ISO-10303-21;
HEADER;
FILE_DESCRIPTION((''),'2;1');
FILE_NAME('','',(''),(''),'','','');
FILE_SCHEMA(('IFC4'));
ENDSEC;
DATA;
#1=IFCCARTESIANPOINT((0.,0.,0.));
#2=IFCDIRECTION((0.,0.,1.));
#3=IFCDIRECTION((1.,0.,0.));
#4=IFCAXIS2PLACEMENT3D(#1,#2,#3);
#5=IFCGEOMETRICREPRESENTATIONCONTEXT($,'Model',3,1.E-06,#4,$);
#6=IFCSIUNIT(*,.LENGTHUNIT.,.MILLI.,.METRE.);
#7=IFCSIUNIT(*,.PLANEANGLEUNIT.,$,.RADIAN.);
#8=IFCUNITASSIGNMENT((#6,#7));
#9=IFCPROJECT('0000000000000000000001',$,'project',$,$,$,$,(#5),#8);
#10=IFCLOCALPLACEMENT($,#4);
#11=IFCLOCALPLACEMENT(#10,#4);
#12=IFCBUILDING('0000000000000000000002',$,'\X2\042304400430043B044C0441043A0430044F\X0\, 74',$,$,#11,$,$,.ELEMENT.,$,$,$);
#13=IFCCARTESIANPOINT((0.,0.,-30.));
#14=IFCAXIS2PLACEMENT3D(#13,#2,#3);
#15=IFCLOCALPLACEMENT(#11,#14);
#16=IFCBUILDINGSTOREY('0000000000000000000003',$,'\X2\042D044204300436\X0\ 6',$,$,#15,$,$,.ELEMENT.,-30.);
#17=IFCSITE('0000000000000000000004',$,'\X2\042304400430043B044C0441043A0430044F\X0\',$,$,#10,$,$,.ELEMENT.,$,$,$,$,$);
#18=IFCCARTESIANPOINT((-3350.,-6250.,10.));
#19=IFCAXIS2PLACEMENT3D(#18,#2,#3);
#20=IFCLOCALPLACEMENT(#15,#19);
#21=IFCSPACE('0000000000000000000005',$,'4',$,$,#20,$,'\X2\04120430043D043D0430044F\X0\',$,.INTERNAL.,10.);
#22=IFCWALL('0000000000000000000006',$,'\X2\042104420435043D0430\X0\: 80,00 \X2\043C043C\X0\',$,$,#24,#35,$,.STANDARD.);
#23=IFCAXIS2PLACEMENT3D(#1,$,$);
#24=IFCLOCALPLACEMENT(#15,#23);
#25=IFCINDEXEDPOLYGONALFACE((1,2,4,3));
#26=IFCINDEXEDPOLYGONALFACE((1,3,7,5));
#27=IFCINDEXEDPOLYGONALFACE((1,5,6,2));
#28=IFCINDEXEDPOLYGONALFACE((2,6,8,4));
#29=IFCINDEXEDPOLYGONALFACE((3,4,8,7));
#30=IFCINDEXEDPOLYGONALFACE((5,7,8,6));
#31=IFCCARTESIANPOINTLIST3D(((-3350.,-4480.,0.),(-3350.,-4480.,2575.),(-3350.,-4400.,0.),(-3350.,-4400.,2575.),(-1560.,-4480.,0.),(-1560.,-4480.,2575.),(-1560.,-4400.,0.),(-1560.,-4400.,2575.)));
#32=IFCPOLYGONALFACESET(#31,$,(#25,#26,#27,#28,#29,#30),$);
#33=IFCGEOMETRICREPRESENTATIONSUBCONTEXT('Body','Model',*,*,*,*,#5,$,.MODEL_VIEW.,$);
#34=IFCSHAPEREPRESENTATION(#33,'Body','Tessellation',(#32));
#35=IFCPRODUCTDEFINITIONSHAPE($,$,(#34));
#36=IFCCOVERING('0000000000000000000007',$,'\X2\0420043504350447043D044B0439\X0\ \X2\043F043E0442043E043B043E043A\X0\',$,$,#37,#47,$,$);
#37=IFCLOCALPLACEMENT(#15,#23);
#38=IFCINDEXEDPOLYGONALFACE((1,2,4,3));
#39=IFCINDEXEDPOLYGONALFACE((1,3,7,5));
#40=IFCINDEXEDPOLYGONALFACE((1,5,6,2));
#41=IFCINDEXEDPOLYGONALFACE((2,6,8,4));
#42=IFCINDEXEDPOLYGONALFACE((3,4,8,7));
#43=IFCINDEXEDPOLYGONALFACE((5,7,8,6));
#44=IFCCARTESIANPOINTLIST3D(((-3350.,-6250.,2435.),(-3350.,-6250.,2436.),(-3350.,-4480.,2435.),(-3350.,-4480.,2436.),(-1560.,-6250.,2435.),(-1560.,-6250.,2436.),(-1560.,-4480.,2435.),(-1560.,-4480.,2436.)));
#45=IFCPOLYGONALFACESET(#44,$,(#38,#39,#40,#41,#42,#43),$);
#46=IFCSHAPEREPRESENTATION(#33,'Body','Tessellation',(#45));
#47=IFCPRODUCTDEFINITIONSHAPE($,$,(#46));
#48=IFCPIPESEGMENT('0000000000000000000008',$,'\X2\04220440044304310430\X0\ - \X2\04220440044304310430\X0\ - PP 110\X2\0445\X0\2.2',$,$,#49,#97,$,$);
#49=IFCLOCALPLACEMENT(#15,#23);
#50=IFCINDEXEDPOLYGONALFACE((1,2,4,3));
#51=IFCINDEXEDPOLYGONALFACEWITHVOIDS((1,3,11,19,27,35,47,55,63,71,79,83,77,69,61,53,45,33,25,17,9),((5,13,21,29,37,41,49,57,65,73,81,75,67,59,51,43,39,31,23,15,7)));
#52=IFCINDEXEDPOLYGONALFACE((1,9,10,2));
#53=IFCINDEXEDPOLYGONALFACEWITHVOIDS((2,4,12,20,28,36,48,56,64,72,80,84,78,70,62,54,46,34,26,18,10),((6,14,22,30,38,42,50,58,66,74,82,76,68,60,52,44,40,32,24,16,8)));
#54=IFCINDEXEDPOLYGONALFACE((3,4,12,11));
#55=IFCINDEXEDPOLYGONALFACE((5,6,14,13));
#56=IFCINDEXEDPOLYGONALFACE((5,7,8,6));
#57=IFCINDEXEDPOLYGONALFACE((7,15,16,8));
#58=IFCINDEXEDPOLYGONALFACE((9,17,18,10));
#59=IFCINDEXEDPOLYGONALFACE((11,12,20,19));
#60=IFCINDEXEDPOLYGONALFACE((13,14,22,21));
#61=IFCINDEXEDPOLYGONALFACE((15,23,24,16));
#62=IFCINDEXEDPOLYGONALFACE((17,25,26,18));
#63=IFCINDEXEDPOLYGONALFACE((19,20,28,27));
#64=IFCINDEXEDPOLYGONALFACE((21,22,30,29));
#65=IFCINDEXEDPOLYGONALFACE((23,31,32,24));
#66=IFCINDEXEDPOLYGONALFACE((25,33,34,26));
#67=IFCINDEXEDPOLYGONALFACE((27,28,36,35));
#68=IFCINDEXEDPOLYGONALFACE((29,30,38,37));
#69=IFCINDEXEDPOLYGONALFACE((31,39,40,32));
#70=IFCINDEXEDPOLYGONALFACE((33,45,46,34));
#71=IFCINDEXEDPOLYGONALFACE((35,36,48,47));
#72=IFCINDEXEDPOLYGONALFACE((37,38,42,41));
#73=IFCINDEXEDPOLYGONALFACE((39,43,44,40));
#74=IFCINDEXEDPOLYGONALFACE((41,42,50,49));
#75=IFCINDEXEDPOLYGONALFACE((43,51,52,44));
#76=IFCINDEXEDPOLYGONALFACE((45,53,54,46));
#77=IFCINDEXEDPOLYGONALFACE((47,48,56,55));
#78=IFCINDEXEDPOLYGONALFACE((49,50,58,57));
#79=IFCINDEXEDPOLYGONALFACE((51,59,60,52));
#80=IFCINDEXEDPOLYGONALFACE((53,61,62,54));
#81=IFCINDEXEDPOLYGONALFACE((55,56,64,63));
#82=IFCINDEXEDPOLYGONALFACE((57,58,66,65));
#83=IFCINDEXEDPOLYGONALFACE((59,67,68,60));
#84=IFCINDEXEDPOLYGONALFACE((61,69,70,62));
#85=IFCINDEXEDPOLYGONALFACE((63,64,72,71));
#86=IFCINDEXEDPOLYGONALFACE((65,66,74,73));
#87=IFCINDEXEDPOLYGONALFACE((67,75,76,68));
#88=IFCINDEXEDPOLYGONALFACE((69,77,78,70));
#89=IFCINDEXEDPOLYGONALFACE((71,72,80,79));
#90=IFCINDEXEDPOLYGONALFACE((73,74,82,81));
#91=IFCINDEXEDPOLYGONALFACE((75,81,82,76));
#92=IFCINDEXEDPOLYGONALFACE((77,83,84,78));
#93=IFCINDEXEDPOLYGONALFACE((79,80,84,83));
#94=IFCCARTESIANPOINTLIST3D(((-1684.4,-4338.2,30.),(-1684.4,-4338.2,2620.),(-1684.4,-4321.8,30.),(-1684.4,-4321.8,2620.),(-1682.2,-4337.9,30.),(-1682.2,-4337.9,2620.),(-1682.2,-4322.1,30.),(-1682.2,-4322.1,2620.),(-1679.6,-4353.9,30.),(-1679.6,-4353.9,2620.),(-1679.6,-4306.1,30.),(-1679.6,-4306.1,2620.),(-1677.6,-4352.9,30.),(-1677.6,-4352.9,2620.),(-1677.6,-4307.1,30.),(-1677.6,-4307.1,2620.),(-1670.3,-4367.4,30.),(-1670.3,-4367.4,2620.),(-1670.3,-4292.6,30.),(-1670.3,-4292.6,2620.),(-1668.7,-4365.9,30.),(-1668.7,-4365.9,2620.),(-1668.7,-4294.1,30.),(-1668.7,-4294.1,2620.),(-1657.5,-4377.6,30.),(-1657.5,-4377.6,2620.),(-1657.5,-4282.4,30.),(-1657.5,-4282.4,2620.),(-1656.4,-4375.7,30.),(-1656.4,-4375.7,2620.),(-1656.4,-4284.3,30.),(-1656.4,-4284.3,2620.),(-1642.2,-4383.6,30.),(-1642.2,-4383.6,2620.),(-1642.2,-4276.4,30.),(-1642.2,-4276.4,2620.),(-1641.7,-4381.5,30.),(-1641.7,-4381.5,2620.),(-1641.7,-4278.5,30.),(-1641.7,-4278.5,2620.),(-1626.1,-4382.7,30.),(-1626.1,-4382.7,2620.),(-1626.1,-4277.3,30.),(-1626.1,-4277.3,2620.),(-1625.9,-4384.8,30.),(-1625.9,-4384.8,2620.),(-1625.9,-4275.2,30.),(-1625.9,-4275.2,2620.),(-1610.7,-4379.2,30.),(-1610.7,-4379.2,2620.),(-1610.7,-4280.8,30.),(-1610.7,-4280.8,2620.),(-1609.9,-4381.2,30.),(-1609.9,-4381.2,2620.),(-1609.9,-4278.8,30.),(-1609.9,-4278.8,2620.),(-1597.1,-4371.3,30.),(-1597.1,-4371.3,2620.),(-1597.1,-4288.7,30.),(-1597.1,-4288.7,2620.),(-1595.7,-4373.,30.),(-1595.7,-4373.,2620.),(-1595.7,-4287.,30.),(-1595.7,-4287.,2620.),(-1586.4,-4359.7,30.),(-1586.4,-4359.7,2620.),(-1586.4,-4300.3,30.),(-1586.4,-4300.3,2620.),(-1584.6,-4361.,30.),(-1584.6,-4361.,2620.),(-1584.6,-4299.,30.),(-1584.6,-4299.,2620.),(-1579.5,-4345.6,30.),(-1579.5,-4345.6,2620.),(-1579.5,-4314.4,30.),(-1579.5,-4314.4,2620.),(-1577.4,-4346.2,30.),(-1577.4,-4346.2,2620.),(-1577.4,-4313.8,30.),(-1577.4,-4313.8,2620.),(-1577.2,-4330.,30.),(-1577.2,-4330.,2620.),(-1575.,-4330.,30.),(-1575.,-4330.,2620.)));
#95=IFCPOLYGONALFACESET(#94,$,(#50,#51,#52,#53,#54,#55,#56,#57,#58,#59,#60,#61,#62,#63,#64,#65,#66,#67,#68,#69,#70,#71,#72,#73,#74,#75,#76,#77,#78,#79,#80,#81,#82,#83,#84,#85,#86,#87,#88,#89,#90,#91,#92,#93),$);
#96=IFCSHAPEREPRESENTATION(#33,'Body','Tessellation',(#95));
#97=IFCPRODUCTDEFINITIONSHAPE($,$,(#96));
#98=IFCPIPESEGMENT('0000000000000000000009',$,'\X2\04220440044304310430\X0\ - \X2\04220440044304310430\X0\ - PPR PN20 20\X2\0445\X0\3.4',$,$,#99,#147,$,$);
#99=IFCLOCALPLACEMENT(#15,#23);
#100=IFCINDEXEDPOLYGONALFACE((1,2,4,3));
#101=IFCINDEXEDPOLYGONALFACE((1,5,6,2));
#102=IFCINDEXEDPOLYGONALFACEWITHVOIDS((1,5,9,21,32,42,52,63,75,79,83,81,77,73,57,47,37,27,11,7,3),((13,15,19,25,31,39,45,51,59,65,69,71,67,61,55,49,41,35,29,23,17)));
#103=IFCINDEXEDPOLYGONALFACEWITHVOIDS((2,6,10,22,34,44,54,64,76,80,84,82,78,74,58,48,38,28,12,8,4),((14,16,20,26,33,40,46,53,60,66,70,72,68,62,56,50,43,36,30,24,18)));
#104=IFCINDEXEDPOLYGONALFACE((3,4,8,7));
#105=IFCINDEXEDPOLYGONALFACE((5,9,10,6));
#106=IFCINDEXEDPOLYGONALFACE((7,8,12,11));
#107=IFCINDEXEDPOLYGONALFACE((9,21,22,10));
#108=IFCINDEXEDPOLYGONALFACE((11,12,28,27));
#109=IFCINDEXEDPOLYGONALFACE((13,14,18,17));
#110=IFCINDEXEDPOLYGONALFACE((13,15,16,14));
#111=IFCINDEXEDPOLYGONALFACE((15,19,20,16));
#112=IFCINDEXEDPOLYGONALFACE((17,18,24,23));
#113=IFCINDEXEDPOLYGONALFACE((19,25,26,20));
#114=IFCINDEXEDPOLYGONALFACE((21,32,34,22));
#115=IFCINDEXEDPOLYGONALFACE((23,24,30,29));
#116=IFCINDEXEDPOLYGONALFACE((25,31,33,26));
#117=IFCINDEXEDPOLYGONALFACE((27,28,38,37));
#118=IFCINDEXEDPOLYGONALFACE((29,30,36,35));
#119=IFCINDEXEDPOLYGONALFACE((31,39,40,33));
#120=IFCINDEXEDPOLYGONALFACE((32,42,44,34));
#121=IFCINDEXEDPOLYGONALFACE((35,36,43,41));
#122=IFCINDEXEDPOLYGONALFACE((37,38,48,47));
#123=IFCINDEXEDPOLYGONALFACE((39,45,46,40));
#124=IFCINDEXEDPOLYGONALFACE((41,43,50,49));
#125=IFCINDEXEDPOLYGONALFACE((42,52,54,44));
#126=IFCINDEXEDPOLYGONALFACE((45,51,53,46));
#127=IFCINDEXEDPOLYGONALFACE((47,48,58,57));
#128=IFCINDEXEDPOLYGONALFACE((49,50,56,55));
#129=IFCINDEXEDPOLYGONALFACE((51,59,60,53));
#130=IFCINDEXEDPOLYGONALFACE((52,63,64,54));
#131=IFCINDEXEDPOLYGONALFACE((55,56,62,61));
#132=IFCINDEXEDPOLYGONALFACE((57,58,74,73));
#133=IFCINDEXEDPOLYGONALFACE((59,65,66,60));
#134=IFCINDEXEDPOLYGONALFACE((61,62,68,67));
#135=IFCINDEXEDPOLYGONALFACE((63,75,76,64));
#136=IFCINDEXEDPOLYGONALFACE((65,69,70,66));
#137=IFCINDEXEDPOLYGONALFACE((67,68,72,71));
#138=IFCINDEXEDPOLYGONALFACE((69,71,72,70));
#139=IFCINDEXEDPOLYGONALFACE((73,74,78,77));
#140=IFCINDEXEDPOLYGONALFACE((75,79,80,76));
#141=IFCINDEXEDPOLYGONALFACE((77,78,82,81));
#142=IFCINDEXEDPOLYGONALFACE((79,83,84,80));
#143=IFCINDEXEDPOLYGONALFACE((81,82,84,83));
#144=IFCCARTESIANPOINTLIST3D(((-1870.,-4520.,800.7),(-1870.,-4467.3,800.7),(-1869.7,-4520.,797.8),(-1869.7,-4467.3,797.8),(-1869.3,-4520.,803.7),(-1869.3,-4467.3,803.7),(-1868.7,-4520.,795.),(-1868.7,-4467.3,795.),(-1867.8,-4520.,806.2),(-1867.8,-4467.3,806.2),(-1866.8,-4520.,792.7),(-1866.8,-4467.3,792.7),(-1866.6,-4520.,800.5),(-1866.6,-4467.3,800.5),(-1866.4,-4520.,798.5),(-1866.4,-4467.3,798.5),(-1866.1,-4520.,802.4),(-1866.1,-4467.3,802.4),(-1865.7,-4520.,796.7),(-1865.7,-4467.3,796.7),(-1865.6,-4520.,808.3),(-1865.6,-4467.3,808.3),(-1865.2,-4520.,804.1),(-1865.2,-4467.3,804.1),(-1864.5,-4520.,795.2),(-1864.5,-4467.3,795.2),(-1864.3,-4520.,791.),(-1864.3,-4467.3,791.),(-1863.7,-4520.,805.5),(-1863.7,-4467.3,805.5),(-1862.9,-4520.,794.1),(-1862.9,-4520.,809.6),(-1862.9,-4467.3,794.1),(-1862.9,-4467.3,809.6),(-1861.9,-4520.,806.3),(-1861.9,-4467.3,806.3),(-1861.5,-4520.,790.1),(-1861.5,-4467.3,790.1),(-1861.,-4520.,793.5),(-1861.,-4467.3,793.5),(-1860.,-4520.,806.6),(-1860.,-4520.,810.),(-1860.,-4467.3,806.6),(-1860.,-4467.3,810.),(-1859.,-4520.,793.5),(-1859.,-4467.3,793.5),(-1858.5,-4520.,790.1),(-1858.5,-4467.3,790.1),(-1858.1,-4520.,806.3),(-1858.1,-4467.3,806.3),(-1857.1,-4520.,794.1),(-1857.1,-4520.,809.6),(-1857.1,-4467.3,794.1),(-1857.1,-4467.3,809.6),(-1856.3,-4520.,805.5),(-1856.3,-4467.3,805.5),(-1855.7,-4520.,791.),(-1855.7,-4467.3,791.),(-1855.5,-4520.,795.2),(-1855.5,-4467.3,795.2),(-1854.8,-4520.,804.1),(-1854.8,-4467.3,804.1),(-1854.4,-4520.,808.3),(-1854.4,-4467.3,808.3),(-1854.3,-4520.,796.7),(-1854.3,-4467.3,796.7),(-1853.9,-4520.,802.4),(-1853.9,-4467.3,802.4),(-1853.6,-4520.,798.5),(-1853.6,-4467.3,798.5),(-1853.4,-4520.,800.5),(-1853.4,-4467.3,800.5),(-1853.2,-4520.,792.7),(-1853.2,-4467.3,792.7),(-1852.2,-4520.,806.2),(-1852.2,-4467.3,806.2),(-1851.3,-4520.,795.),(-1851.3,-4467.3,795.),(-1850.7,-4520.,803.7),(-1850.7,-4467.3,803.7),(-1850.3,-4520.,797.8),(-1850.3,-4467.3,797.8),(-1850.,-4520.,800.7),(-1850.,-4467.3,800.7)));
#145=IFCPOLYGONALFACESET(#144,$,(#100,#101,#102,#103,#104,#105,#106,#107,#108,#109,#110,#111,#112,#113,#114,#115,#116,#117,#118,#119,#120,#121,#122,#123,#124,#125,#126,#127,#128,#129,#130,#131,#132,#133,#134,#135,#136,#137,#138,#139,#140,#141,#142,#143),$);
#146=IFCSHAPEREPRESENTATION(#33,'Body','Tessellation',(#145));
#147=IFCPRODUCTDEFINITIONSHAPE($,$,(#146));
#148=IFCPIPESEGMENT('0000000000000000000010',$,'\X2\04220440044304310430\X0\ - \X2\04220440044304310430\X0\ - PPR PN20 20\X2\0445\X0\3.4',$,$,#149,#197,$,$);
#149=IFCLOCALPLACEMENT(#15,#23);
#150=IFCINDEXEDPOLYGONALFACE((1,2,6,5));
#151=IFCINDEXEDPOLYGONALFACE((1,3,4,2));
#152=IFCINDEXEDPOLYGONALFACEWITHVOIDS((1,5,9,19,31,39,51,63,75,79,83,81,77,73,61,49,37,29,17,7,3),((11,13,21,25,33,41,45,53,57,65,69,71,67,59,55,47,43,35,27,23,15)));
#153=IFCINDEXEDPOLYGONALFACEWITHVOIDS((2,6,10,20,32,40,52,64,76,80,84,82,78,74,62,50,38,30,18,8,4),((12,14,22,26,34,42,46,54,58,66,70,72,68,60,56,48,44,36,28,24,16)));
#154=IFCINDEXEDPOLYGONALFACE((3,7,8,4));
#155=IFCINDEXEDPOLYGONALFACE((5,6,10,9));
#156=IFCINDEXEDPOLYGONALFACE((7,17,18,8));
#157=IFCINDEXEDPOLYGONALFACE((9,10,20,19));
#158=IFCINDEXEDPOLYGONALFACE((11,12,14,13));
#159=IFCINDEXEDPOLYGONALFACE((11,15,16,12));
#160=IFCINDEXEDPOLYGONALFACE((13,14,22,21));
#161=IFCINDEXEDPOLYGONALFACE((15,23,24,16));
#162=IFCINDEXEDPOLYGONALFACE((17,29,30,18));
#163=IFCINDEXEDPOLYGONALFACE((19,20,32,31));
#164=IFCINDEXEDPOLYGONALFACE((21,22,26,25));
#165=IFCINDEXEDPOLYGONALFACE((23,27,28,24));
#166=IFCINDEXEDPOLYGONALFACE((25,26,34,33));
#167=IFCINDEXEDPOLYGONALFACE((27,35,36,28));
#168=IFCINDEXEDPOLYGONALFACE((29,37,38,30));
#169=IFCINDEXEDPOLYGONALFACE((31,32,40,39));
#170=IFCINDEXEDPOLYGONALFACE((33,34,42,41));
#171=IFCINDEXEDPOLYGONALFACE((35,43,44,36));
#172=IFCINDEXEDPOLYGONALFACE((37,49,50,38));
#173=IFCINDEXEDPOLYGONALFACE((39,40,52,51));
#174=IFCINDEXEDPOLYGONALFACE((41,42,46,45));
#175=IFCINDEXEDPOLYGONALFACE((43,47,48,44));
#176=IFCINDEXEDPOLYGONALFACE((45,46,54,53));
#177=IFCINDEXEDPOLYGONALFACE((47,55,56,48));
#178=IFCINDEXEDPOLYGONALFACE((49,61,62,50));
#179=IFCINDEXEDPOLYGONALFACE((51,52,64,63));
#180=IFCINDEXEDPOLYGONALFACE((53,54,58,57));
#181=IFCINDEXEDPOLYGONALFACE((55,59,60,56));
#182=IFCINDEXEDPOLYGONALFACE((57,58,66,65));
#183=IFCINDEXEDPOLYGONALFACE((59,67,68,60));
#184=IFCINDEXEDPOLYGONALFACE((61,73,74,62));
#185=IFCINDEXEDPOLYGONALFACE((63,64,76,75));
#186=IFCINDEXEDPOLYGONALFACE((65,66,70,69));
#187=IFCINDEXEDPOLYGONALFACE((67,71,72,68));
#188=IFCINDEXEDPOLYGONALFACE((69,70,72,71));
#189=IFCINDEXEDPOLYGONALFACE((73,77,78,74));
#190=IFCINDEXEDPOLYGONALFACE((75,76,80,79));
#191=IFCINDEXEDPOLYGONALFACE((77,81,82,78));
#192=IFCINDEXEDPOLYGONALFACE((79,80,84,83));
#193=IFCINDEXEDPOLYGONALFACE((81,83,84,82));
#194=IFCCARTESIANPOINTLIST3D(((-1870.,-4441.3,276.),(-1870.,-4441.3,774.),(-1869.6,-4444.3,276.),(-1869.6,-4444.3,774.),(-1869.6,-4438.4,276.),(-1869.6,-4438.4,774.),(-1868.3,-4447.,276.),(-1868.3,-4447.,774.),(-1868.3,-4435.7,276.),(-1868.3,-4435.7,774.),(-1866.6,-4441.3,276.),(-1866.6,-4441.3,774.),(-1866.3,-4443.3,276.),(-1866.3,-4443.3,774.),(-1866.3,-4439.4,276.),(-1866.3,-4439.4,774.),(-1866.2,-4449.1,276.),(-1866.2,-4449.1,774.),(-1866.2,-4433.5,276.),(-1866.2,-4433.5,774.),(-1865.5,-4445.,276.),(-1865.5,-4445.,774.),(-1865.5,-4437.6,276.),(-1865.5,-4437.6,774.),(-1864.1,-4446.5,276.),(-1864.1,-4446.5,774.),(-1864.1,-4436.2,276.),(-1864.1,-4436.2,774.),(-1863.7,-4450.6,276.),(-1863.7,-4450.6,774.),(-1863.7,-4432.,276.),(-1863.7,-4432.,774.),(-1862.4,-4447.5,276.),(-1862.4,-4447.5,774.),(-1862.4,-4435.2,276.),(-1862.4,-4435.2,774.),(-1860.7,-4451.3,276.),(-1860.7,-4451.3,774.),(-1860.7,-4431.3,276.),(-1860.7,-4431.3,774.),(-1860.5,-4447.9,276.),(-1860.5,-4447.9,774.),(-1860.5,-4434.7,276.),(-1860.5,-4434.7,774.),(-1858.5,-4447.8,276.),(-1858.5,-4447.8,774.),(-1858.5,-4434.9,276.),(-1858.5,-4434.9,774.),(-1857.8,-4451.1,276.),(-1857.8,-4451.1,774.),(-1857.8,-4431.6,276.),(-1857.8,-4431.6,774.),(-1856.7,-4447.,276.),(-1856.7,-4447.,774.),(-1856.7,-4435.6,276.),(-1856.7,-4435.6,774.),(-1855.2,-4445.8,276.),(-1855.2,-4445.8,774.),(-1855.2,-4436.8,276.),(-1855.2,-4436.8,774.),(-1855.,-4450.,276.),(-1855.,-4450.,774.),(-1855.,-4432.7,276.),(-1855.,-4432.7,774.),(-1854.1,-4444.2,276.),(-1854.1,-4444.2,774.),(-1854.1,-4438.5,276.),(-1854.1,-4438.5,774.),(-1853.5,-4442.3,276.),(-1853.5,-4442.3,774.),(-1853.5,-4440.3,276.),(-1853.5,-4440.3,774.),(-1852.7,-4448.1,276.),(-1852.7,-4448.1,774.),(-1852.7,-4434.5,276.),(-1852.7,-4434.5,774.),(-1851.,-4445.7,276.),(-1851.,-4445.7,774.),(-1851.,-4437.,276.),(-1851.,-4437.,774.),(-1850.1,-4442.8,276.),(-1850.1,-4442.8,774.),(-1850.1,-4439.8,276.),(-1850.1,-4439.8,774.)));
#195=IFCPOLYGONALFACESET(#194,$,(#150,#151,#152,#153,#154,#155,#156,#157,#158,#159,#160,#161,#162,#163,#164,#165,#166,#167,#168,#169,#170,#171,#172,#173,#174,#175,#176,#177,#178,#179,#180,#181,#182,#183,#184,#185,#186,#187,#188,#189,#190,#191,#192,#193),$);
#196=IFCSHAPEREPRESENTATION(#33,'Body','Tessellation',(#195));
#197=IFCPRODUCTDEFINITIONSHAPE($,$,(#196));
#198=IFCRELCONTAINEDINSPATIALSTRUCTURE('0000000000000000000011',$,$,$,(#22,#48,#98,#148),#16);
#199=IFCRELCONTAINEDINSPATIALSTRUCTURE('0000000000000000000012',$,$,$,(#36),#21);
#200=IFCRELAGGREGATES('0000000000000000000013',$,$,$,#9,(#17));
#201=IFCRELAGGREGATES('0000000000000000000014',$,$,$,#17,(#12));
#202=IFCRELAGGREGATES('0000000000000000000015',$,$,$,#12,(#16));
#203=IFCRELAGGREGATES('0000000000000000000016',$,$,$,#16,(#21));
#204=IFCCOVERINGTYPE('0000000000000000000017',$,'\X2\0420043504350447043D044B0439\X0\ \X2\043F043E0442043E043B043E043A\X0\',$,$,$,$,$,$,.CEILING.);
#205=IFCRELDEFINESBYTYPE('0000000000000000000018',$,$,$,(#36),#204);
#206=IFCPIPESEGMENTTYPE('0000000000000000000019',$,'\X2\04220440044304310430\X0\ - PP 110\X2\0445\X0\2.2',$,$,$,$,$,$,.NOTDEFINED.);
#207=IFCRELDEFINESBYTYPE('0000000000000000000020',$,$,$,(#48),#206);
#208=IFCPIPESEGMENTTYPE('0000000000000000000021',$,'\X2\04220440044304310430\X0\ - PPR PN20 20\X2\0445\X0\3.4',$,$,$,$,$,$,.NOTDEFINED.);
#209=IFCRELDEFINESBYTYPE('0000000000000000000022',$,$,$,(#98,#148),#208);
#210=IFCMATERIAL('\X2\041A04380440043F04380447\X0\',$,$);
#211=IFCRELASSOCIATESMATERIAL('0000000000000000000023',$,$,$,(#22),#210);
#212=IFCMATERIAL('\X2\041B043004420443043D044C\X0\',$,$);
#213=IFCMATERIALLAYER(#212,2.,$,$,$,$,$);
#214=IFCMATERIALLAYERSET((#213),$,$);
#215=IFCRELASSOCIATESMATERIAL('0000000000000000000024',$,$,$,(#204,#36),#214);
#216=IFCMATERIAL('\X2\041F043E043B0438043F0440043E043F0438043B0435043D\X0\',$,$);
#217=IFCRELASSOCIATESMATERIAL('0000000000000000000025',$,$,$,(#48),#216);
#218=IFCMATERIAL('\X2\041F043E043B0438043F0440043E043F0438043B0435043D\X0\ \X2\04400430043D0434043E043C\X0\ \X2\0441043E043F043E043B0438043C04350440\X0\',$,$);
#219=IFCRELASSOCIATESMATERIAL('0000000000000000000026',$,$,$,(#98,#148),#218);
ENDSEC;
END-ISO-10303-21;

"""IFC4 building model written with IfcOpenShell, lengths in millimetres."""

from ifc_helpers import new_model, entity, si_unit, frame, origin_with_axes, place, context, subcontext, project, spatial, line, indexed_curve, outline, extrude, material, layer, layer_set, layer_usage, type_object, element, save


model = new_model("IFC4")

# Units and contexts
model_context = context("Model", 3, precision=1e-06, world=origin_with_axes())
body_context = subcontext(model_context, "Body", "Model", "MODEL_VIEW")
ifc_project = project(units=[si_unit("LENGTHUNIT", "METRE", prefix="MILLI"), si_unit("PLANEANGLEUNIT", "RADIAN")], contexts=[model_context])

# Site, building, storey
site_placement = place(None, origin_with_axes())
site = spatial("IfcSite", under=ifc_project, at=site_placement, Name="Уральская", CompositionType="ELEMENT")
building_placement = place(site_placement, origin_with_axes())
building = spatial("IfcBuilding", under=site, at=building_placement, Name="Уральская, 74", CompositionType="ELEMENT")
storey_placement = place(building_placement, frame((0.0, 0.0, -30.0), z_axis=(0.0, 0.0, 1.0), x_axis=(1.0, 0.0, 0.0)))
storey = spatial("IfcBuildingStorey", under=building, at=storey_placement, Name="Этаж 6", CompositionType="ELEMENT", Elevation=-30.0)

# Wall
ifc_material_1 = material(Name="Кирпич")
wall_placement = place(storey_placement, frame((-3350.0, -4400.0, 0.0), z_axis=(0.0, 0.0, 1.0), x_axis=(1.0, 0.0, 0.0)))
element("IfcWall", 1, at=wall_placement, inside=storey, material=ifc_material_1, Name="Стена: 80,00 мм", PredefinedType="STANDARD", context=body_context, shape_type="SweptSolid", body=[
    extrude(outline(indexed_curve([(-40.0, -895.0), (40.0, -895.0), (40.0, 895.0), (-40.0, 895.0)], segments=[line(3, 2), line(2, 1), line(1, 4), line(4, 3)], self_intersect=False)), frame((895.0, -40.0, 0.0), z_axis=(0.0, 0.0, -1.0), x_axis=(0.0, 1.0, 0.0)), (0.0, 0.0, -1.0), 2575.0),
])

# Shared definitions
space_1_placement = place(storey_placement, frame((-3350.0, -6250.0, 10.0), z_axis=(0.0, 0.0, 1.0), x_axis=(1.0, 0.0, 0.0)))
space_1 = spatial("IfcSpace", under=storey, at=space_1_placement, Name="4", LongName="Ванная", PredefinedType="INTERNAL", ElevationWithFlooring=10.0)

# Covering
ifc_material_2 = material(Name="Латунь")
ifc_layer = layer(ifc_material_2, 2.0)
ifc_layer_set = layer_set([ifc_layer])
ifc_layer_usage = layer_usage(ifc_layer_set, "AXIS3", "POSITIVE", 0.0)
covering_type = type_object("IfcCoveringType", Name="Реечный потолок", PredefinedType="CEILING", material=ifc_layer_set)
covering_1_placement = place(space_1_placement, frame((1790.0, 0.0, 2425.0), z_axis=(0.0, 0.0, 1.0), x_axis=(1.0, 0.0, 0.0)))
element("IfcCovering", 2, at=covering_1_placement, inside=space_1, type_object=covering_type, material=ifc_layer_usage, Name="Реечный потолок", context=body_context, shape_type="SweptSolid", body=[
    extrude(outline(indexed_curve([(-1790.0, 0.0), (0.0, 0.0), (0.0, 1770.0), (-1790.0, 1770.0)], segments=[line(3, 2), line(2, 1), line(1, 4), line(4, 3)], self_intersect=False)), None, (0.0, 0.0, 1.0), 1.0),
])

# Pipe segments
ifc_material_3 = material(Name="Полипропилен")
pipe_segment_type_1 = type_object("IfcPipeSegmentType", Name="Труба - PP 110х2.2", PredefinedType="NOTDEFINED")
pipe_segment_1_placement = place(storey_placement, frame((-1630.0, -4330.0, 2620.0), z_axis=(0.0, 0.0, 1.0), x_axis=(-1.0, 0.0, 0.0)))
element("IfcPipeSegment", 3, at=pipe_segment_1_placement, inside=storey, type_object=pipe_segment_type_1, material=ifc_material_3, Name="Труба - Труба - PP 110х2.2", context=body_context, shape_type="AdvancedSweptSolid", body=[
    entity("IfcSweptDiskSolid", entity("IfcIndexedPolyCurve", entity("IfcCartesianPointList3D", [[0.0, 0.0, 0.0], [0.0, 0.0, -2590.0]]), [entity("IfcLineIndex", [1, 2])]), 55.0, 52.8),
])
ifc_material_4 = material(Name="Полипропилен рандом сополимер")
pipe_segment_type_2 = type_object("IfcPipeSegmentType", Name="Труба - PPR PN20 20х3.4", PredefinedType="NOTDEFINED")
pipe_segment_2_placement = place(storey_placement, frame((-1860.0, -4520.0, 800.0), z_axis=(0.0, 0.0, 1.0), x_axis=(0.0, 1.0, 0.0)))
element("IfcPipeSegment", 4, at=pipe_segment_2_placement, inside=storey, type_object=pipe_segment_type_2, material=ifc_material_4, Name="Труба - Труба - PPR PN20 20х3.4", context=body_context, shape_type="AdvancedSweptSolid", body=[
    entity("IfcSweptDiskSolid", entity("IfcIndexedPolyCurve", entity("IfcCartesianPointList3D", [[0.0, 0.0, 0.0], [52.7, 0.0, 0.0]]), [entity("IfcLineIndex", [1, 2])]), 10.0, 6.6),
])
pipe_segment_3_placement = place(storey_placement, frame((-1860.0, -4441.3, 774.0), z_axis=(0.0, 0.0, 1.0), x_axis=(1.0, 0.0, 0.0)))
element("IfcPipeSegment", 5, at=pipe_segment_3_placement, inside=storey, type_object=pipe_segment_type_2, material=ifc_material_4, Name="Труба - Труба - PPR PN20 20х3.4", context=body_context, shape_type="AdvancedSweptSolid", body=[
    entity("IfcSweptDiskSolid", entity("IfcIndexedPolyCurve", entity("IfcCartesianPointList3D", [[0.0, 0.0, 0.0], [0.0, 0.0, -498.0]]), [entity("IfcLineIndex", [1, 2])]), 10.0, 6.6),
])

save(model, "model.ifc")
